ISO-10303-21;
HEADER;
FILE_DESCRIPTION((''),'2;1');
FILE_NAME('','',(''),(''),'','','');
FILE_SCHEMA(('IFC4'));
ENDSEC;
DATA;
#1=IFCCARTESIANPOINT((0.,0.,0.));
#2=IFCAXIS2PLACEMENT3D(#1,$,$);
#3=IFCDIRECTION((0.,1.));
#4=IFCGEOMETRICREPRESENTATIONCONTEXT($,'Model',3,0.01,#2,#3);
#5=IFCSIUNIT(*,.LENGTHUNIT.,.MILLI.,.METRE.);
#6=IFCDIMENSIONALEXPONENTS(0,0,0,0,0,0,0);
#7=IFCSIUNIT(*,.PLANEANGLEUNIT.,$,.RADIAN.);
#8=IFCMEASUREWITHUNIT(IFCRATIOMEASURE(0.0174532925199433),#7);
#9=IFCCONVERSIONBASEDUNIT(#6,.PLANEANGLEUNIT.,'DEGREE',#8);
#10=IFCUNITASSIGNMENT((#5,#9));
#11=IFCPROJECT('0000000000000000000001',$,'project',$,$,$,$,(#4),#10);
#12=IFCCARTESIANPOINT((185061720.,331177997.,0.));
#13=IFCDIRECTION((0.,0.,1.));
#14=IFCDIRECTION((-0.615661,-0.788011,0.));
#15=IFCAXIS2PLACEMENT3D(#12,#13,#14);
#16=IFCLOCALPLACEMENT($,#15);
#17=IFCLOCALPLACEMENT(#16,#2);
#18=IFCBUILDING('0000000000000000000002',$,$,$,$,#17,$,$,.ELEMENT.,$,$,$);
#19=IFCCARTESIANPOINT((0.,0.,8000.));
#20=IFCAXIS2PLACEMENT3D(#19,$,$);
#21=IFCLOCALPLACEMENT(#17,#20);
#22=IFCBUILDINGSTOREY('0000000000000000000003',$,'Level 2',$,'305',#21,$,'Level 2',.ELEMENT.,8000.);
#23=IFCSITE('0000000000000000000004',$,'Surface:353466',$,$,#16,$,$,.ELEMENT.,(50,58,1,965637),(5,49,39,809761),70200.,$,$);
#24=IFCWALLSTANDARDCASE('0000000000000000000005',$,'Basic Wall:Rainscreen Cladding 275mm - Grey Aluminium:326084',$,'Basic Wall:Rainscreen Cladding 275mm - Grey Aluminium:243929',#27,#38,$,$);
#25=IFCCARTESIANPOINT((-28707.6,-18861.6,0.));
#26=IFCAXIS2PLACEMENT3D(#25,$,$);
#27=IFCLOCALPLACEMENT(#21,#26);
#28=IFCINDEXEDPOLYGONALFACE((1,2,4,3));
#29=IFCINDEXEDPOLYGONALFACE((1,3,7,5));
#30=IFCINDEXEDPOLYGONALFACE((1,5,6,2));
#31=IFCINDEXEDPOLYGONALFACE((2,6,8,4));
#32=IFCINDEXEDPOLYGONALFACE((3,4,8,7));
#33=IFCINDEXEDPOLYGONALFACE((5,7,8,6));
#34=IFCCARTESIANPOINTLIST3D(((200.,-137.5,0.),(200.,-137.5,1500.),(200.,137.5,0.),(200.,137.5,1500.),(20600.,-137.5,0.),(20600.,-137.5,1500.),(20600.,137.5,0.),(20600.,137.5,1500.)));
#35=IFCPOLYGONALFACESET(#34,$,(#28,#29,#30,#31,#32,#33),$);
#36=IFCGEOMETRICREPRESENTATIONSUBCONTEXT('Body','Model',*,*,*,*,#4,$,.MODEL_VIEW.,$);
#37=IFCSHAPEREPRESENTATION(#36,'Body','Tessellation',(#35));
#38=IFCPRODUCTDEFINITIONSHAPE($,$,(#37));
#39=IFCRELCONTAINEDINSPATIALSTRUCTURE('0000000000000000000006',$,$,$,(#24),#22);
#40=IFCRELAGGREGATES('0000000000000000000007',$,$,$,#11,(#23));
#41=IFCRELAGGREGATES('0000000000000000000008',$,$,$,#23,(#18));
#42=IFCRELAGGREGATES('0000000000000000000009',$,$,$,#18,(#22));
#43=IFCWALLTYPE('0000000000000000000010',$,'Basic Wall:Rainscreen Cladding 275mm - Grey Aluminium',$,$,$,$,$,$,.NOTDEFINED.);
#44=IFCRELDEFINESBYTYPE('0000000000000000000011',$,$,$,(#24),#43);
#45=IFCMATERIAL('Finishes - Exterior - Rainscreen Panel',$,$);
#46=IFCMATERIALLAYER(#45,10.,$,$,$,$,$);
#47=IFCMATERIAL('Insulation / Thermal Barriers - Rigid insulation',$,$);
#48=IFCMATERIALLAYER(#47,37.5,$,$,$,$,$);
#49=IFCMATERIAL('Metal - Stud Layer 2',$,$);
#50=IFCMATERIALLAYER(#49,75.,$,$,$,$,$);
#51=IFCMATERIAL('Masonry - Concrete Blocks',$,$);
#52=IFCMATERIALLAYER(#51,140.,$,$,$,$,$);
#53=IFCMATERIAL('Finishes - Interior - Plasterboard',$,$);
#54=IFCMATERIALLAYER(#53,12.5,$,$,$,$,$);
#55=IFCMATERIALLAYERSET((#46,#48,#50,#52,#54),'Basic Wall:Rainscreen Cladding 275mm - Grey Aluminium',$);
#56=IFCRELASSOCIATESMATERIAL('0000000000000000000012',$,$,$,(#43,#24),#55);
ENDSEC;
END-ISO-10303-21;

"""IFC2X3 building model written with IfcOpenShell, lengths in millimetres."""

from ifc_helpers import new_model, entity, si_unit, converted_unit, direction, frame, frame_2d, origin, place, context, subcontext, project, spatial, rectangle, extrude, clip, halfspace, material, layer, layer_set, layer_usage, type_object, element, save


model = new_model("IFC2X3")

# Units and contexts
model_context = context("Model", 3, precision=0.01, world=origin(), true_north=direction((0.0, 1.0)))
body_context = subcontext(model_context, "Body", "Model", "MODEL_VIEW")
ifc_project = project(units=[si_unit("LENGTHUNIT", "METRE", prefix="MILLI"), converted_unit("PLANEANGLEUNIT", "DEGREE", entity("IfcRatioMeasure", 0.0174532925199433), si_unit("PLANEANGLEUNIT", "RADIAN"), dimensions=[0, 0, 0, 0, 0, 0, 0])], contexts=[model_context])

# Site, building, storey
site_placement = place(None, frame((185061720.0, 331177997.0, 0.0), z_axis=(0.0, 0.0, 1.0), x_axis=(-0.615661, -0.788011, 0.0)))
site = spatial("IfcSite", under=ifc_project, at=site_placement, Name="Surface:353466", CompositionType="ELEMENT", RefLatitude=(50, 58, 1, 965637), RefLongitude=(5, 49, 39, 809761), RefElevation=70200.0)
building_placement = place(site_placement, origin())
building = spatial("IfcBuilding", under=site, at=building_placement, CompositionType="ELEMENT")
storey_placement = place(building_placement, frame((0.0, 0.0, 8000.0)))
storey = spatial("IfcBuildingStorey", under=building, at=storey_placement, Name="Level 2", ObjectType="305", LongName="Level 2", CompositionType="ELEMENT", Elevation=8000.0)

# Wall
ifc_material_1 = material(Name="Finishes - Exterior - Rainscreen Panel")
ifc_layer_1 = layer(ifc_material_1, 10.0)
ifc_material_2 = material(Name="Insulation / Thermal Barriers - Rigid insulation")
ifc_layer_2 = layer(ifc_material_2, 37.5)
ifc_material_3 = material(Name="Metal - Stud Layer 2")
ifc_layer_3 = layer(ifc_material_3, 75.0)
ifc_material_4 = material(Name="Masonry - Concrete Blocks")
ifc_layer_4 = layer(ifc_material_4, 140.0)
ifc_material_5 = material(Name="Finishes - Interior - Plasterboard")
ifc_layer_5 = layer(ifc_material_5, 12.5)
ifc_layer_set_1 = layer_set([ifc_layer_1, ifc_layer_2, ifc_layer_3, ifc_layer_4, ifc_layer_5], Name="Basic Wall:Rainscreen Cladding 275mm - Grey Aluminium")
ifc_layer_usage_1 = layer_usage(ifc_layer_set_1, "AXIS2", "POSITIVE", -137.5)
wall_type_1 = type_object("IfcWallType", Name="Basic Wall:Rainscreen Cladding 275mm - Grey Aluminium", PredefinedType="NOTDEFINED", material=ifc_layer_set_1)
wall_1_placement = place(storey_placement, frame((-28707.6, -18861.6, 0.0)))
element("IfcWallStandardCase", 1, at=wall_1_placement, inside=storey, type_object=wall_type_1, material=ifc_layer_usage_1, Name="Basic Wall:Rainscreen Cladding 275mm - Grey Aluminium:326084", ObjectType="Basic Wall:Rainscreen Cladding 275mm - Grey Aluminium:243929", context=body_context, shape_type="Clipping", body=[
    clip(extrude(rectangle(XDim=20400.0, YDim=275.0, at=frame_2d((10400.0, 0.0), x_axis=(1.0, 0.0))), origin(), (0.0, 0.0, 1.0), 1500.0), halfspace(frame((0.0, 0.0, -8000.0)), True)),
])

save(model, "model.ifc")
